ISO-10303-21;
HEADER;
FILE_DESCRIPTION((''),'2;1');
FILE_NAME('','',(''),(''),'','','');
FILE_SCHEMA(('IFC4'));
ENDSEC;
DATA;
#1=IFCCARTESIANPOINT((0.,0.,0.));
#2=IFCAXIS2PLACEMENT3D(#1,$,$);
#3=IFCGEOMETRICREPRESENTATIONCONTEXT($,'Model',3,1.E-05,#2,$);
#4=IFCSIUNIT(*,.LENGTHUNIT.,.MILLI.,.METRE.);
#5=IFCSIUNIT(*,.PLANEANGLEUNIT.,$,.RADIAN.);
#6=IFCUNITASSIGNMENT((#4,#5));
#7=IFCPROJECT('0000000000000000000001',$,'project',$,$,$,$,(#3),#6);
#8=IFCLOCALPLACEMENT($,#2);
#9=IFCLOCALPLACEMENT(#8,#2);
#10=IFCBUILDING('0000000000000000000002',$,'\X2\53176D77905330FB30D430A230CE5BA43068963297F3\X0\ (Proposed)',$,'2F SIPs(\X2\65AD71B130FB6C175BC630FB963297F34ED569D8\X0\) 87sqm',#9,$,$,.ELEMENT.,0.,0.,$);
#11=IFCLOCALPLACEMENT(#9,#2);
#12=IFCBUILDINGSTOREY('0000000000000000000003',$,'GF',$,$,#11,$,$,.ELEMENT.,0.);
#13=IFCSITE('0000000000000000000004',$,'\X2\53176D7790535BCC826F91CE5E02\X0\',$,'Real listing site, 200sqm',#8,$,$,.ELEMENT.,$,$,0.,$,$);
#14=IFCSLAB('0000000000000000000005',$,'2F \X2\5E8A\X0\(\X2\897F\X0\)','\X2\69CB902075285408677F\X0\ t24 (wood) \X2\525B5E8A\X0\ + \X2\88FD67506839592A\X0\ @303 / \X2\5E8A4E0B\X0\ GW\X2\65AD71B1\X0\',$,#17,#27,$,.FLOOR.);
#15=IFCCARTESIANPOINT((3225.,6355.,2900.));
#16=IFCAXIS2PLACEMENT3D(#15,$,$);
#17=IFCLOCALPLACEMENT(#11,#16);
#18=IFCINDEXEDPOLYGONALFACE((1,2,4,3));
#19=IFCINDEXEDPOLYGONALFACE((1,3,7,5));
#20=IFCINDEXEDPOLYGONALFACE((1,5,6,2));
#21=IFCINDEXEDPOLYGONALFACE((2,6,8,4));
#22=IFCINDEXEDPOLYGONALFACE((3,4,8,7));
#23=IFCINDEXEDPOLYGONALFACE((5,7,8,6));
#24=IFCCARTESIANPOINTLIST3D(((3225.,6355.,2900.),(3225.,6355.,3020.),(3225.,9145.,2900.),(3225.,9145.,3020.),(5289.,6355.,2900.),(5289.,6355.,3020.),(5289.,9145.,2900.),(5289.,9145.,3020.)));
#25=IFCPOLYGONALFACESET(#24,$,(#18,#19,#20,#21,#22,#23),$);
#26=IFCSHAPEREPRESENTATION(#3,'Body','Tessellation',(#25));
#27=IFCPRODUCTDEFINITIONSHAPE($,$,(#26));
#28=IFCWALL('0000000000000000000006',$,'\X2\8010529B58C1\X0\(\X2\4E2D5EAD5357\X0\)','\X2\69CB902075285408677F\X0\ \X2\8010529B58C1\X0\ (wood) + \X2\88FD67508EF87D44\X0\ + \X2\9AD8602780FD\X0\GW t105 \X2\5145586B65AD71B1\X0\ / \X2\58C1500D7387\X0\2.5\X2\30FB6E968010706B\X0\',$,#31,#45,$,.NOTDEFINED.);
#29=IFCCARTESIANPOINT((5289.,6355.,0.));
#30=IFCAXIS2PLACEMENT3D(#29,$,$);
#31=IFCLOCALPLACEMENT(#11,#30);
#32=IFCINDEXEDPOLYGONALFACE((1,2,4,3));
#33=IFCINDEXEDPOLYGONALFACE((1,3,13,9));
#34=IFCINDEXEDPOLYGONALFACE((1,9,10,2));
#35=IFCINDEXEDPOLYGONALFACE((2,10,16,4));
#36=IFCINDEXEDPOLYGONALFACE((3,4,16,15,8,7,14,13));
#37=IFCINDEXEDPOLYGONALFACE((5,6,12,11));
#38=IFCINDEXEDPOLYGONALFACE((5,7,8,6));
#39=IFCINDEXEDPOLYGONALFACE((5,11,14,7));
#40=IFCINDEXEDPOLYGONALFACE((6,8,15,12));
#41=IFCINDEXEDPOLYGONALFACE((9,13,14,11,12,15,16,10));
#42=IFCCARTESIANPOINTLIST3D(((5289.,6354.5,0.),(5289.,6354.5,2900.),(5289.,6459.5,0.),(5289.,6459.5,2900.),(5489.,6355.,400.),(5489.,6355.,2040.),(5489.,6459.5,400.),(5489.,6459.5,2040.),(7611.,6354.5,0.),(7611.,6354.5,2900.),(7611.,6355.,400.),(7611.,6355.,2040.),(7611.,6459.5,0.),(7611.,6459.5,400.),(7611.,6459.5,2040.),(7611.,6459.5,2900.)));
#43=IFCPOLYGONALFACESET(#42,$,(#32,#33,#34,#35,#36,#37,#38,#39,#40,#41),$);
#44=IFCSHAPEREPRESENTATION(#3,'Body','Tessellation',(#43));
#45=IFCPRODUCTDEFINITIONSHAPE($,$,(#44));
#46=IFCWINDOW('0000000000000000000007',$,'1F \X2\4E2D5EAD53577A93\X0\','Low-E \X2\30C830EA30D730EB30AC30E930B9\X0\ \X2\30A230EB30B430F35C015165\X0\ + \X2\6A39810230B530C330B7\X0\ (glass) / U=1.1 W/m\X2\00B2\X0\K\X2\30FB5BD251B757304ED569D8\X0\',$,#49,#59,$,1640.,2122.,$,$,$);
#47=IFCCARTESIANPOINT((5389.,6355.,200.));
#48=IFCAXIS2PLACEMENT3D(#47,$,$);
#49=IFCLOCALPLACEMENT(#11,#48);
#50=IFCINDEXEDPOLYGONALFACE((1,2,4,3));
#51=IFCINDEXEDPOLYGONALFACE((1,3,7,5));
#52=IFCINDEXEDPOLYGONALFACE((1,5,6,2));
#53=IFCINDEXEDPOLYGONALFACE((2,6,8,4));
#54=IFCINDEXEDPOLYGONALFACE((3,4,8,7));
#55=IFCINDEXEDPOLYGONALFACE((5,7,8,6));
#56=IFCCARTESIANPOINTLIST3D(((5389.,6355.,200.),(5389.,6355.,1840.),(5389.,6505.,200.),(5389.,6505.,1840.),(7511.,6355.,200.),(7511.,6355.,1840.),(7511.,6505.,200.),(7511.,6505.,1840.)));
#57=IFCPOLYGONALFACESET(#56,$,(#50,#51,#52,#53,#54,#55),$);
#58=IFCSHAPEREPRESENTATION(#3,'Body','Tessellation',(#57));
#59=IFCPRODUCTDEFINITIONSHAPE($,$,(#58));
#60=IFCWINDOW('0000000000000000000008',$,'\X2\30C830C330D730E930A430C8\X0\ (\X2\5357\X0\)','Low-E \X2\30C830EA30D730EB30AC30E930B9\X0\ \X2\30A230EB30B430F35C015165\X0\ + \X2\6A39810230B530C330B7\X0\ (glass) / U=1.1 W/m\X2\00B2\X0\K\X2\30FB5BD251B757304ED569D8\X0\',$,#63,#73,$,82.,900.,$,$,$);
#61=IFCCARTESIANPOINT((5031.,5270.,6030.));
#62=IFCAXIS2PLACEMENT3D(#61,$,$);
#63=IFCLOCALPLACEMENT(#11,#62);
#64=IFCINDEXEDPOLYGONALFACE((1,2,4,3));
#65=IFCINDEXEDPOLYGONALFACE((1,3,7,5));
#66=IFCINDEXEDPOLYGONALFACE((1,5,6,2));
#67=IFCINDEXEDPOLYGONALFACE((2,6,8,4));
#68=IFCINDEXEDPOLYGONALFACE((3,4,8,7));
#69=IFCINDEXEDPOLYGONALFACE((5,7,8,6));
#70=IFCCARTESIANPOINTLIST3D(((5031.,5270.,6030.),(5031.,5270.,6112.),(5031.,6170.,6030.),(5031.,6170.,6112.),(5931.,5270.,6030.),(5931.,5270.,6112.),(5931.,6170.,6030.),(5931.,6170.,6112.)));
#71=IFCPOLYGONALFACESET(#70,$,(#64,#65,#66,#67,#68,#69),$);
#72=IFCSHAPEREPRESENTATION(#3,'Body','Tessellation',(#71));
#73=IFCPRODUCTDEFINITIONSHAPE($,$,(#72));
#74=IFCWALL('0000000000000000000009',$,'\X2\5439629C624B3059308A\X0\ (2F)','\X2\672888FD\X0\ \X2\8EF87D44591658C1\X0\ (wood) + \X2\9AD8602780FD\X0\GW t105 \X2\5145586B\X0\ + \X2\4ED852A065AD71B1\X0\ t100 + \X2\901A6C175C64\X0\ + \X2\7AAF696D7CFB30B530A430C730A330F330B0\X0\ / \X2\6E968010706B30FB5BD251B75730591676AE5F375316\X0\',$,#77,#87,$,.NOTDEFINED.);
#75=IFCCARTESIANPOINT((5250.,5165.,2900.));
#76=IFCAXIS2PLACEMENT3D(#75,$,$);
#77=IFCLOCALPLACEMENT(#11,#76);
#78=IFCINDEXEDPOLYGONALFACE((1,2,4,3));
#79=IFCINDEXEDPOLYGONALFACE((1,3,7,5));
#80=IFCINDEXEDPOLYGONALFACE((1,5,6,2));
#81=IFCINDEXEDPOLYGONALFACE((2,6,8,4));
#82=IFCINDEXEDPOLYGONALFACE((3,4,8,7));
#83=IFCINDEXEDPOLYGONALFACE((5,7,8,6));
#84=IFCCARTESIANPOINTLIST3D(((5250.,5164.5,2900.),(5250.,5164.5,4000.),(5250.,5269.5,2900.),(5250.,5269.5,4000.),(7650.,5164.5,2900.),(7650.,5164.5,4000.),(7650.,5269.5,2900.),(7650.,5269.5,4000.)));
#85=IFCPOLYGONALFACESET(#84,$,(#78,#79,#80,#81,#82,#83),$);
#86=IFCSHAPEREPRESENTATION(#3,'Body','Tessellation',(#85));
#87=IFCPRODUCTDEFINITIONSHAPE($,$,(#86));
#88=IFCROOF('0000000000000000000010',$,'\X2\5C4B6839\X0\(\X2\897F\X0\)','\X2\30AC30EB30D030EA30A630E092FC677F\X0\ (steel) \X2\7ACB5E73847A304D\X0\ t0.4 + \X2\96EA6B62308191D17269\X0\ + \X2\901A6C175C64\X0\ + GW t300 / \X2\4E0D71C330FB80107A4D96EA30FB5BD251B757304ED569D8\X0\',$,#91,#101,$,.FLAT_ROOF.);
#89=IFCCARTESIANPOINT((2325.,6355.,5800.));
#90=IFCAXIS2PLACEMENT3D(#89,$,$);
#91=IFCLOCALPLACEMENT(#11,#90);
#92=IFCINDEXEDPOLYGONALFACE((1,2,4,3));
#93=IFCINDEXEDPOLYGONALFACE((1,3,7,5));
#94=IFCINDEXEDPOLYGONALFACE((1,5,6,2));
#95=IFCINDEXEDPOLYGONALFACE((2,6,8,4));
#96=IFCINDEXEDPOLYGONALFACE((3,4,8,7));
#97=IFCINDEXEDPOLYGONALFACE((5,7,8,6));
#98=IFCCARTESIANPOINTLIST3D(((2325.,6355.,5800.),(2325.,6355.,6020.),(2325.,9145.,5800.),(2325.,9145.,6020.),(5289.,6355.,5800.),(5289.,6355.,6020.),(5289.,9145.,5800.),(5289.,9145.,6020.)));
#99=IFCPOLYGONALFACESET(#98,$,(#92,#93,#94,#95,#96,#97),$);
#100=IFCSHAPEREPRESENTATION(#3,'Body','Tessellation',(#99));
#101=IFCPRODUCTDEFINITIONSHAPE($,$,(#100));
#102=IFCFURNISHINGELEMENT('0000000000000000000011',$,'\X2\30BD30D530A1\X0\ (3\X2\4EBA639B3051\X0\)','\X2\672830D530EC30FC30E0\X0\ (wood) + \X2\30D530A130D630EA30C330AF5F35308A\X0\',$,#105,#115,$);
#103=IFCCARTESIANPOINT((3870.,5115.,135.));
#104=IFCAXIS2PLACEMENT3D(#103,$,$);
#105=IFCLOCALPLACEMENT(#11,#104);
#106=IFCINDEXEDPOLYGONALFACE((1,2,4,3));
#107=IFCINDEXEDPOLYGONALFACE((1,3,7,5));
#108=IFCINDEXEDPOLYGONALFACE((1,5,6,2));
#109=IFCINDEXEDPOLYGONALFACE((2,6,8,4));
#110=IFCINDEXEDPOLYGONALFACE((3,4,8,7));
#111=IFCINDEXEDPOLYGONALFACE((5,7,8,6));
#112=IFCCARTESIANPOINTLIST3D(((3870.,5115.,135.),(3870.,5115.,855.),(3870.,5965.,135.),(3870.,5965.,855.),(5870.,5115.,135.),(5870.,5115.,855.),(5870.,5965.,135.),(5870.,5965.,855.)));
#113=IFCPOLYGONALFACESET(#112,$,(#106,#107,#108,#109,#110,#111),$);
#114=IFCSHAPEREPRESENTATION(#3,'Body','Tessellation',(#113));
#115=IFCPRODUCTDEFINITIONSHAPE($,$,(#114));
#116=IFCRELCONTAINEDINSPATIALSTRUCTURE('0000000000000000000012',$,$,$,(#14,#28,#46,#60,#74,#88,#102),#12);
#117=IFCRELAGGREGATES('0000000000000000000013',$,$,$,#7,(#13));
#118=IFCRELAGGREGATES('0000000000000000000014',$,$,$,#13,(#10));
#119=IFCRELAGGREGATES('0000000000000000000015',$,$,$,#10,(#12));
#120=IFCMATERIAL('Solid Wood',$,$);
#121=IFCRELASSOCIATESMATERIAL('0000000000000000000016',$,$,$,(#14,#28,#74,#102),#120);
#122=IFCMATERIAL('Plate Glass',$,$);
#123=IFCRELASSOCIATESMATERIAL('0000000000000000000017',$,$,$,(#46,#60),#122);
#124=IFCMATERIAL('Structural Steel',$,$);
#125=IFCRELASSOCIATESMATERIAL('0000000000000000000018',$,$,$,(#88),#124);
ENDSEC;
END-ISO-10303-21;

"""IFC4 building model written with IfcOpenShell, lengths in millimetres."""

from ifc_helpers import new_model, si_unit, frame, frame_2d, origin, place, context, project, spatial, rectangle, extrude, material, element, fill, save


model = new_model("IFC4")

# Units and contexts
model_context = context("Model", 3, precision=1e-05, world=origin())
ifc_project = project(units=[si_unit("LENGTHUNIT", "METRE", prefix="MILLI"), si_unit("PLANEANGLEUNIT", "RADIAN")], contexts=[model_context])

# Site, building, storey
site_placement = place(None, origin())
site = spatial("IfcSite", under=ifc_project, at=site_placement, Name="北海道富良野市", ObjectType="Real listing site, 200sqm", CompositionType="ELEMENT", RefElevation=0.0)
building_placement = place(site_placement, origin())
building = spatial("IfcBuilding", under=site, at=building_placement, Name="北海道・ピアノ室と防音 (Proposed)", ObjectType="2F SIPs(断熱・気密・防音仕様) 87sqm", CompositionType="ELEMENT", ElevationOfRefHeight=0.0, ElevationOfTerrain=0.0)
storey_placement = place(building_placement, origin())
storey = spatial("IfcBuildingStorey", under=building, at=storey_placement, Name="GF", CompositionType="ELEMENT", Elevation=0.0)

# Shared definitions
ifc_material_1 = material(Name="Solid Wood")

# Slab
slab_1_placement = place(storey_placement, frame((3225.0, 6355.0, 2900.0)))
element("IfcSlab", 1, at=slab_1_placement, inside=storey, material=ifc_material_1, Name="2F 床(西)", Description="構造用合板 t24 (wood) 剛床 + 製材根太 @303 / 床下 GW断熱", PredefinedType="FLOOR", context=model_context, shape_type="SweptSolid", body=[
    extrude(rectangle(XDim=2064.0, YDim=2790.0, at=frame_2d((1032.0, 1395.0))), frame((3225.0, 6355.0, 2900.0)), (0.0, 0.0, 1.0), 120.0),
])

# Wall, opening, window
wall_1_placement = place(storey_placement, frame((5289.0, 6355.0, 0.0)))
wall_1 = element("IfcWall", 2, at=wall_1_placement, inside=storey, material=ifc_material_1, Name="耐力壁(中庭南)", Description="構造用合板 耐力壁 (wood) + 製材軸組 + 高性能GW t105 充填断熱 / 壁倍率2.5・準耐火", PredefinedType="NOTDEFINED", context=model_context, shape_type="SweptSolid", body=[
    extrude(rectangle(XDim=2322.0, YDim=105.0, at=frame_2d((1161.0, 52.0))), frame((5289.0, 6355.0, 0.0)), (0.0, 0.0, 1.0), 2900.0),
])
opening_placement = place(storey_placement, frame((5389.0, 6355.0, 200.0)))
opening = element("IfcOpeningElement", 3, at=opening_placement, cuts=wall_1, PredefinedType="NOTDEFINED", context=model_context, shape_type="SweptSolid", body=[
    extrude(rectangle(XDim=2122.0, YDim=150.0, at=frame_2d((1061.0, 75.0))), frame((5389.0, 6355.0, 200.0)), (0.0, 0.0, 1.0), 1640.0),
])
ifc_material_2 = material(Name="Plate Glass")
window_1_placement = place(storey_placement, frame((5389.0, 6355.0, 200.0)))
window_1 = element("IfcWindow", 4, at=window_1_placement, inside=storey, material=ifc_material_2, Name="1F 中庭南窓", Description="Low-E トリプルガラス アルゴン封入 + 樹脂サッシ (glass) / U=1.1 W/m²K・寒冷地仕様", OverallHeight=1640.0, OverallWidth=2122.0, context=model_context, shape_type="SweptSolid", body=[
    extrude(rectangle(XDim=2122.0, YDim=150.0, at=frame_2d((1061.0, 75.0))), frame((5389.0, 6355.0, 200.0)), (0.0, 0.0, 1.0), 1640.0),
])
fill(opening, window_1)

# Window
window_2_placement = place(storey_placement, frame((5031.0, 5270.0, 6030.0)))
element("IfcWindow", 5, at=window_2_placement, inside=storey, material=ifc_material_2, Name="トップライト (南)", Description="Low-E トリプルガラス アルゴン封入 + 樹脂サッシ (glass) / U=1.1 W/m²K・寒冷地仕様", OverallHeight=82.0, OverallWidth=900.0, context=model_context, shape_type="SweptSolid", body=[
    extrude(rectangle(XDim=900.0, YDim=900.0, at=frame_2d((450.0, 450.0))), frame((5031.0, 5270.0, 6030.0)), (0.0, 0.0, 1.0), 82.0),
])

# Wall
wall_2_placement = place(storey_placement, frame((5250.0, 5165.0, 2900.0)))
element("IfcWall", 6, at=wall_2_placement, inside=storey, material=ifc_material_1, Name="吹抜手すり (2F)", Description="木製 軸組外壁 (wood) + 高性能GW t105 充填 + 付加断熱 t100 + 通気層 + 窯業系サイディング / 準耐火・寒冷地外皮強化", PredefinedType="NOTDEFINED", context=model_context, shape_type="SweptSolid", body=[
    extrude(rectangle(XDim=2400.0, YDim=105.0, at=frame_2d((1200.0, 52.0))), frame((5250.0, 5165.0, 2900.0)), (0.0, 0.0, 1.0), 1100.0),
])

# Roof
ifc_material_3 = material(Name="Structural Steel")
for number, where, name in (
    (7, (2325.0, 6355.0, 5800.0), "屋根(西)"),
):
    element("IfcRoof", number, at=place(storey_placement, frame(where)), inside=storey, material=ifc_material_3, Name=name, Description="ガルバリウム鋼板 (steel) 立平葺き t0.4 + 雪止め金物 + 通気層 + GW t300 / 不燃・耐積雪・寒冷地仕様", PredefinedType="FLAT_ROOF", context=model_context, shape_type="SweptSolid", body=[
        extrude(rectangle(XDim=2964.0, YDim=2790.0, at=frame_2d((1482.0, 1395.0))), frame((2325.0, 6355.0, 5800.0)), (0.0, 0.0, 1.0), 220.0),
    ])

# Furnishing element
furnishing_placement = place(storey_placement, frame((3870.0, 5115.0, 135.0)))
element("IfcFurnishingElement", 8, at=furnishing_placement, inside=storey, material=ifc_material_1, Name="ソファ (3人掛け)", Description="木フレーム (wood) + ファブリック張り", context=model_context, shape_type="SweptSolid", body=[
    extrude(rectangle(XDim=2000.0, YDim=850.0, at=frame_2d((1000.0, 425.0))), frame((3870.0, 5115.0, 135.0)), (0.0, 0.0, 1.0), 720.0),
])

save(model, "model.ifc")
